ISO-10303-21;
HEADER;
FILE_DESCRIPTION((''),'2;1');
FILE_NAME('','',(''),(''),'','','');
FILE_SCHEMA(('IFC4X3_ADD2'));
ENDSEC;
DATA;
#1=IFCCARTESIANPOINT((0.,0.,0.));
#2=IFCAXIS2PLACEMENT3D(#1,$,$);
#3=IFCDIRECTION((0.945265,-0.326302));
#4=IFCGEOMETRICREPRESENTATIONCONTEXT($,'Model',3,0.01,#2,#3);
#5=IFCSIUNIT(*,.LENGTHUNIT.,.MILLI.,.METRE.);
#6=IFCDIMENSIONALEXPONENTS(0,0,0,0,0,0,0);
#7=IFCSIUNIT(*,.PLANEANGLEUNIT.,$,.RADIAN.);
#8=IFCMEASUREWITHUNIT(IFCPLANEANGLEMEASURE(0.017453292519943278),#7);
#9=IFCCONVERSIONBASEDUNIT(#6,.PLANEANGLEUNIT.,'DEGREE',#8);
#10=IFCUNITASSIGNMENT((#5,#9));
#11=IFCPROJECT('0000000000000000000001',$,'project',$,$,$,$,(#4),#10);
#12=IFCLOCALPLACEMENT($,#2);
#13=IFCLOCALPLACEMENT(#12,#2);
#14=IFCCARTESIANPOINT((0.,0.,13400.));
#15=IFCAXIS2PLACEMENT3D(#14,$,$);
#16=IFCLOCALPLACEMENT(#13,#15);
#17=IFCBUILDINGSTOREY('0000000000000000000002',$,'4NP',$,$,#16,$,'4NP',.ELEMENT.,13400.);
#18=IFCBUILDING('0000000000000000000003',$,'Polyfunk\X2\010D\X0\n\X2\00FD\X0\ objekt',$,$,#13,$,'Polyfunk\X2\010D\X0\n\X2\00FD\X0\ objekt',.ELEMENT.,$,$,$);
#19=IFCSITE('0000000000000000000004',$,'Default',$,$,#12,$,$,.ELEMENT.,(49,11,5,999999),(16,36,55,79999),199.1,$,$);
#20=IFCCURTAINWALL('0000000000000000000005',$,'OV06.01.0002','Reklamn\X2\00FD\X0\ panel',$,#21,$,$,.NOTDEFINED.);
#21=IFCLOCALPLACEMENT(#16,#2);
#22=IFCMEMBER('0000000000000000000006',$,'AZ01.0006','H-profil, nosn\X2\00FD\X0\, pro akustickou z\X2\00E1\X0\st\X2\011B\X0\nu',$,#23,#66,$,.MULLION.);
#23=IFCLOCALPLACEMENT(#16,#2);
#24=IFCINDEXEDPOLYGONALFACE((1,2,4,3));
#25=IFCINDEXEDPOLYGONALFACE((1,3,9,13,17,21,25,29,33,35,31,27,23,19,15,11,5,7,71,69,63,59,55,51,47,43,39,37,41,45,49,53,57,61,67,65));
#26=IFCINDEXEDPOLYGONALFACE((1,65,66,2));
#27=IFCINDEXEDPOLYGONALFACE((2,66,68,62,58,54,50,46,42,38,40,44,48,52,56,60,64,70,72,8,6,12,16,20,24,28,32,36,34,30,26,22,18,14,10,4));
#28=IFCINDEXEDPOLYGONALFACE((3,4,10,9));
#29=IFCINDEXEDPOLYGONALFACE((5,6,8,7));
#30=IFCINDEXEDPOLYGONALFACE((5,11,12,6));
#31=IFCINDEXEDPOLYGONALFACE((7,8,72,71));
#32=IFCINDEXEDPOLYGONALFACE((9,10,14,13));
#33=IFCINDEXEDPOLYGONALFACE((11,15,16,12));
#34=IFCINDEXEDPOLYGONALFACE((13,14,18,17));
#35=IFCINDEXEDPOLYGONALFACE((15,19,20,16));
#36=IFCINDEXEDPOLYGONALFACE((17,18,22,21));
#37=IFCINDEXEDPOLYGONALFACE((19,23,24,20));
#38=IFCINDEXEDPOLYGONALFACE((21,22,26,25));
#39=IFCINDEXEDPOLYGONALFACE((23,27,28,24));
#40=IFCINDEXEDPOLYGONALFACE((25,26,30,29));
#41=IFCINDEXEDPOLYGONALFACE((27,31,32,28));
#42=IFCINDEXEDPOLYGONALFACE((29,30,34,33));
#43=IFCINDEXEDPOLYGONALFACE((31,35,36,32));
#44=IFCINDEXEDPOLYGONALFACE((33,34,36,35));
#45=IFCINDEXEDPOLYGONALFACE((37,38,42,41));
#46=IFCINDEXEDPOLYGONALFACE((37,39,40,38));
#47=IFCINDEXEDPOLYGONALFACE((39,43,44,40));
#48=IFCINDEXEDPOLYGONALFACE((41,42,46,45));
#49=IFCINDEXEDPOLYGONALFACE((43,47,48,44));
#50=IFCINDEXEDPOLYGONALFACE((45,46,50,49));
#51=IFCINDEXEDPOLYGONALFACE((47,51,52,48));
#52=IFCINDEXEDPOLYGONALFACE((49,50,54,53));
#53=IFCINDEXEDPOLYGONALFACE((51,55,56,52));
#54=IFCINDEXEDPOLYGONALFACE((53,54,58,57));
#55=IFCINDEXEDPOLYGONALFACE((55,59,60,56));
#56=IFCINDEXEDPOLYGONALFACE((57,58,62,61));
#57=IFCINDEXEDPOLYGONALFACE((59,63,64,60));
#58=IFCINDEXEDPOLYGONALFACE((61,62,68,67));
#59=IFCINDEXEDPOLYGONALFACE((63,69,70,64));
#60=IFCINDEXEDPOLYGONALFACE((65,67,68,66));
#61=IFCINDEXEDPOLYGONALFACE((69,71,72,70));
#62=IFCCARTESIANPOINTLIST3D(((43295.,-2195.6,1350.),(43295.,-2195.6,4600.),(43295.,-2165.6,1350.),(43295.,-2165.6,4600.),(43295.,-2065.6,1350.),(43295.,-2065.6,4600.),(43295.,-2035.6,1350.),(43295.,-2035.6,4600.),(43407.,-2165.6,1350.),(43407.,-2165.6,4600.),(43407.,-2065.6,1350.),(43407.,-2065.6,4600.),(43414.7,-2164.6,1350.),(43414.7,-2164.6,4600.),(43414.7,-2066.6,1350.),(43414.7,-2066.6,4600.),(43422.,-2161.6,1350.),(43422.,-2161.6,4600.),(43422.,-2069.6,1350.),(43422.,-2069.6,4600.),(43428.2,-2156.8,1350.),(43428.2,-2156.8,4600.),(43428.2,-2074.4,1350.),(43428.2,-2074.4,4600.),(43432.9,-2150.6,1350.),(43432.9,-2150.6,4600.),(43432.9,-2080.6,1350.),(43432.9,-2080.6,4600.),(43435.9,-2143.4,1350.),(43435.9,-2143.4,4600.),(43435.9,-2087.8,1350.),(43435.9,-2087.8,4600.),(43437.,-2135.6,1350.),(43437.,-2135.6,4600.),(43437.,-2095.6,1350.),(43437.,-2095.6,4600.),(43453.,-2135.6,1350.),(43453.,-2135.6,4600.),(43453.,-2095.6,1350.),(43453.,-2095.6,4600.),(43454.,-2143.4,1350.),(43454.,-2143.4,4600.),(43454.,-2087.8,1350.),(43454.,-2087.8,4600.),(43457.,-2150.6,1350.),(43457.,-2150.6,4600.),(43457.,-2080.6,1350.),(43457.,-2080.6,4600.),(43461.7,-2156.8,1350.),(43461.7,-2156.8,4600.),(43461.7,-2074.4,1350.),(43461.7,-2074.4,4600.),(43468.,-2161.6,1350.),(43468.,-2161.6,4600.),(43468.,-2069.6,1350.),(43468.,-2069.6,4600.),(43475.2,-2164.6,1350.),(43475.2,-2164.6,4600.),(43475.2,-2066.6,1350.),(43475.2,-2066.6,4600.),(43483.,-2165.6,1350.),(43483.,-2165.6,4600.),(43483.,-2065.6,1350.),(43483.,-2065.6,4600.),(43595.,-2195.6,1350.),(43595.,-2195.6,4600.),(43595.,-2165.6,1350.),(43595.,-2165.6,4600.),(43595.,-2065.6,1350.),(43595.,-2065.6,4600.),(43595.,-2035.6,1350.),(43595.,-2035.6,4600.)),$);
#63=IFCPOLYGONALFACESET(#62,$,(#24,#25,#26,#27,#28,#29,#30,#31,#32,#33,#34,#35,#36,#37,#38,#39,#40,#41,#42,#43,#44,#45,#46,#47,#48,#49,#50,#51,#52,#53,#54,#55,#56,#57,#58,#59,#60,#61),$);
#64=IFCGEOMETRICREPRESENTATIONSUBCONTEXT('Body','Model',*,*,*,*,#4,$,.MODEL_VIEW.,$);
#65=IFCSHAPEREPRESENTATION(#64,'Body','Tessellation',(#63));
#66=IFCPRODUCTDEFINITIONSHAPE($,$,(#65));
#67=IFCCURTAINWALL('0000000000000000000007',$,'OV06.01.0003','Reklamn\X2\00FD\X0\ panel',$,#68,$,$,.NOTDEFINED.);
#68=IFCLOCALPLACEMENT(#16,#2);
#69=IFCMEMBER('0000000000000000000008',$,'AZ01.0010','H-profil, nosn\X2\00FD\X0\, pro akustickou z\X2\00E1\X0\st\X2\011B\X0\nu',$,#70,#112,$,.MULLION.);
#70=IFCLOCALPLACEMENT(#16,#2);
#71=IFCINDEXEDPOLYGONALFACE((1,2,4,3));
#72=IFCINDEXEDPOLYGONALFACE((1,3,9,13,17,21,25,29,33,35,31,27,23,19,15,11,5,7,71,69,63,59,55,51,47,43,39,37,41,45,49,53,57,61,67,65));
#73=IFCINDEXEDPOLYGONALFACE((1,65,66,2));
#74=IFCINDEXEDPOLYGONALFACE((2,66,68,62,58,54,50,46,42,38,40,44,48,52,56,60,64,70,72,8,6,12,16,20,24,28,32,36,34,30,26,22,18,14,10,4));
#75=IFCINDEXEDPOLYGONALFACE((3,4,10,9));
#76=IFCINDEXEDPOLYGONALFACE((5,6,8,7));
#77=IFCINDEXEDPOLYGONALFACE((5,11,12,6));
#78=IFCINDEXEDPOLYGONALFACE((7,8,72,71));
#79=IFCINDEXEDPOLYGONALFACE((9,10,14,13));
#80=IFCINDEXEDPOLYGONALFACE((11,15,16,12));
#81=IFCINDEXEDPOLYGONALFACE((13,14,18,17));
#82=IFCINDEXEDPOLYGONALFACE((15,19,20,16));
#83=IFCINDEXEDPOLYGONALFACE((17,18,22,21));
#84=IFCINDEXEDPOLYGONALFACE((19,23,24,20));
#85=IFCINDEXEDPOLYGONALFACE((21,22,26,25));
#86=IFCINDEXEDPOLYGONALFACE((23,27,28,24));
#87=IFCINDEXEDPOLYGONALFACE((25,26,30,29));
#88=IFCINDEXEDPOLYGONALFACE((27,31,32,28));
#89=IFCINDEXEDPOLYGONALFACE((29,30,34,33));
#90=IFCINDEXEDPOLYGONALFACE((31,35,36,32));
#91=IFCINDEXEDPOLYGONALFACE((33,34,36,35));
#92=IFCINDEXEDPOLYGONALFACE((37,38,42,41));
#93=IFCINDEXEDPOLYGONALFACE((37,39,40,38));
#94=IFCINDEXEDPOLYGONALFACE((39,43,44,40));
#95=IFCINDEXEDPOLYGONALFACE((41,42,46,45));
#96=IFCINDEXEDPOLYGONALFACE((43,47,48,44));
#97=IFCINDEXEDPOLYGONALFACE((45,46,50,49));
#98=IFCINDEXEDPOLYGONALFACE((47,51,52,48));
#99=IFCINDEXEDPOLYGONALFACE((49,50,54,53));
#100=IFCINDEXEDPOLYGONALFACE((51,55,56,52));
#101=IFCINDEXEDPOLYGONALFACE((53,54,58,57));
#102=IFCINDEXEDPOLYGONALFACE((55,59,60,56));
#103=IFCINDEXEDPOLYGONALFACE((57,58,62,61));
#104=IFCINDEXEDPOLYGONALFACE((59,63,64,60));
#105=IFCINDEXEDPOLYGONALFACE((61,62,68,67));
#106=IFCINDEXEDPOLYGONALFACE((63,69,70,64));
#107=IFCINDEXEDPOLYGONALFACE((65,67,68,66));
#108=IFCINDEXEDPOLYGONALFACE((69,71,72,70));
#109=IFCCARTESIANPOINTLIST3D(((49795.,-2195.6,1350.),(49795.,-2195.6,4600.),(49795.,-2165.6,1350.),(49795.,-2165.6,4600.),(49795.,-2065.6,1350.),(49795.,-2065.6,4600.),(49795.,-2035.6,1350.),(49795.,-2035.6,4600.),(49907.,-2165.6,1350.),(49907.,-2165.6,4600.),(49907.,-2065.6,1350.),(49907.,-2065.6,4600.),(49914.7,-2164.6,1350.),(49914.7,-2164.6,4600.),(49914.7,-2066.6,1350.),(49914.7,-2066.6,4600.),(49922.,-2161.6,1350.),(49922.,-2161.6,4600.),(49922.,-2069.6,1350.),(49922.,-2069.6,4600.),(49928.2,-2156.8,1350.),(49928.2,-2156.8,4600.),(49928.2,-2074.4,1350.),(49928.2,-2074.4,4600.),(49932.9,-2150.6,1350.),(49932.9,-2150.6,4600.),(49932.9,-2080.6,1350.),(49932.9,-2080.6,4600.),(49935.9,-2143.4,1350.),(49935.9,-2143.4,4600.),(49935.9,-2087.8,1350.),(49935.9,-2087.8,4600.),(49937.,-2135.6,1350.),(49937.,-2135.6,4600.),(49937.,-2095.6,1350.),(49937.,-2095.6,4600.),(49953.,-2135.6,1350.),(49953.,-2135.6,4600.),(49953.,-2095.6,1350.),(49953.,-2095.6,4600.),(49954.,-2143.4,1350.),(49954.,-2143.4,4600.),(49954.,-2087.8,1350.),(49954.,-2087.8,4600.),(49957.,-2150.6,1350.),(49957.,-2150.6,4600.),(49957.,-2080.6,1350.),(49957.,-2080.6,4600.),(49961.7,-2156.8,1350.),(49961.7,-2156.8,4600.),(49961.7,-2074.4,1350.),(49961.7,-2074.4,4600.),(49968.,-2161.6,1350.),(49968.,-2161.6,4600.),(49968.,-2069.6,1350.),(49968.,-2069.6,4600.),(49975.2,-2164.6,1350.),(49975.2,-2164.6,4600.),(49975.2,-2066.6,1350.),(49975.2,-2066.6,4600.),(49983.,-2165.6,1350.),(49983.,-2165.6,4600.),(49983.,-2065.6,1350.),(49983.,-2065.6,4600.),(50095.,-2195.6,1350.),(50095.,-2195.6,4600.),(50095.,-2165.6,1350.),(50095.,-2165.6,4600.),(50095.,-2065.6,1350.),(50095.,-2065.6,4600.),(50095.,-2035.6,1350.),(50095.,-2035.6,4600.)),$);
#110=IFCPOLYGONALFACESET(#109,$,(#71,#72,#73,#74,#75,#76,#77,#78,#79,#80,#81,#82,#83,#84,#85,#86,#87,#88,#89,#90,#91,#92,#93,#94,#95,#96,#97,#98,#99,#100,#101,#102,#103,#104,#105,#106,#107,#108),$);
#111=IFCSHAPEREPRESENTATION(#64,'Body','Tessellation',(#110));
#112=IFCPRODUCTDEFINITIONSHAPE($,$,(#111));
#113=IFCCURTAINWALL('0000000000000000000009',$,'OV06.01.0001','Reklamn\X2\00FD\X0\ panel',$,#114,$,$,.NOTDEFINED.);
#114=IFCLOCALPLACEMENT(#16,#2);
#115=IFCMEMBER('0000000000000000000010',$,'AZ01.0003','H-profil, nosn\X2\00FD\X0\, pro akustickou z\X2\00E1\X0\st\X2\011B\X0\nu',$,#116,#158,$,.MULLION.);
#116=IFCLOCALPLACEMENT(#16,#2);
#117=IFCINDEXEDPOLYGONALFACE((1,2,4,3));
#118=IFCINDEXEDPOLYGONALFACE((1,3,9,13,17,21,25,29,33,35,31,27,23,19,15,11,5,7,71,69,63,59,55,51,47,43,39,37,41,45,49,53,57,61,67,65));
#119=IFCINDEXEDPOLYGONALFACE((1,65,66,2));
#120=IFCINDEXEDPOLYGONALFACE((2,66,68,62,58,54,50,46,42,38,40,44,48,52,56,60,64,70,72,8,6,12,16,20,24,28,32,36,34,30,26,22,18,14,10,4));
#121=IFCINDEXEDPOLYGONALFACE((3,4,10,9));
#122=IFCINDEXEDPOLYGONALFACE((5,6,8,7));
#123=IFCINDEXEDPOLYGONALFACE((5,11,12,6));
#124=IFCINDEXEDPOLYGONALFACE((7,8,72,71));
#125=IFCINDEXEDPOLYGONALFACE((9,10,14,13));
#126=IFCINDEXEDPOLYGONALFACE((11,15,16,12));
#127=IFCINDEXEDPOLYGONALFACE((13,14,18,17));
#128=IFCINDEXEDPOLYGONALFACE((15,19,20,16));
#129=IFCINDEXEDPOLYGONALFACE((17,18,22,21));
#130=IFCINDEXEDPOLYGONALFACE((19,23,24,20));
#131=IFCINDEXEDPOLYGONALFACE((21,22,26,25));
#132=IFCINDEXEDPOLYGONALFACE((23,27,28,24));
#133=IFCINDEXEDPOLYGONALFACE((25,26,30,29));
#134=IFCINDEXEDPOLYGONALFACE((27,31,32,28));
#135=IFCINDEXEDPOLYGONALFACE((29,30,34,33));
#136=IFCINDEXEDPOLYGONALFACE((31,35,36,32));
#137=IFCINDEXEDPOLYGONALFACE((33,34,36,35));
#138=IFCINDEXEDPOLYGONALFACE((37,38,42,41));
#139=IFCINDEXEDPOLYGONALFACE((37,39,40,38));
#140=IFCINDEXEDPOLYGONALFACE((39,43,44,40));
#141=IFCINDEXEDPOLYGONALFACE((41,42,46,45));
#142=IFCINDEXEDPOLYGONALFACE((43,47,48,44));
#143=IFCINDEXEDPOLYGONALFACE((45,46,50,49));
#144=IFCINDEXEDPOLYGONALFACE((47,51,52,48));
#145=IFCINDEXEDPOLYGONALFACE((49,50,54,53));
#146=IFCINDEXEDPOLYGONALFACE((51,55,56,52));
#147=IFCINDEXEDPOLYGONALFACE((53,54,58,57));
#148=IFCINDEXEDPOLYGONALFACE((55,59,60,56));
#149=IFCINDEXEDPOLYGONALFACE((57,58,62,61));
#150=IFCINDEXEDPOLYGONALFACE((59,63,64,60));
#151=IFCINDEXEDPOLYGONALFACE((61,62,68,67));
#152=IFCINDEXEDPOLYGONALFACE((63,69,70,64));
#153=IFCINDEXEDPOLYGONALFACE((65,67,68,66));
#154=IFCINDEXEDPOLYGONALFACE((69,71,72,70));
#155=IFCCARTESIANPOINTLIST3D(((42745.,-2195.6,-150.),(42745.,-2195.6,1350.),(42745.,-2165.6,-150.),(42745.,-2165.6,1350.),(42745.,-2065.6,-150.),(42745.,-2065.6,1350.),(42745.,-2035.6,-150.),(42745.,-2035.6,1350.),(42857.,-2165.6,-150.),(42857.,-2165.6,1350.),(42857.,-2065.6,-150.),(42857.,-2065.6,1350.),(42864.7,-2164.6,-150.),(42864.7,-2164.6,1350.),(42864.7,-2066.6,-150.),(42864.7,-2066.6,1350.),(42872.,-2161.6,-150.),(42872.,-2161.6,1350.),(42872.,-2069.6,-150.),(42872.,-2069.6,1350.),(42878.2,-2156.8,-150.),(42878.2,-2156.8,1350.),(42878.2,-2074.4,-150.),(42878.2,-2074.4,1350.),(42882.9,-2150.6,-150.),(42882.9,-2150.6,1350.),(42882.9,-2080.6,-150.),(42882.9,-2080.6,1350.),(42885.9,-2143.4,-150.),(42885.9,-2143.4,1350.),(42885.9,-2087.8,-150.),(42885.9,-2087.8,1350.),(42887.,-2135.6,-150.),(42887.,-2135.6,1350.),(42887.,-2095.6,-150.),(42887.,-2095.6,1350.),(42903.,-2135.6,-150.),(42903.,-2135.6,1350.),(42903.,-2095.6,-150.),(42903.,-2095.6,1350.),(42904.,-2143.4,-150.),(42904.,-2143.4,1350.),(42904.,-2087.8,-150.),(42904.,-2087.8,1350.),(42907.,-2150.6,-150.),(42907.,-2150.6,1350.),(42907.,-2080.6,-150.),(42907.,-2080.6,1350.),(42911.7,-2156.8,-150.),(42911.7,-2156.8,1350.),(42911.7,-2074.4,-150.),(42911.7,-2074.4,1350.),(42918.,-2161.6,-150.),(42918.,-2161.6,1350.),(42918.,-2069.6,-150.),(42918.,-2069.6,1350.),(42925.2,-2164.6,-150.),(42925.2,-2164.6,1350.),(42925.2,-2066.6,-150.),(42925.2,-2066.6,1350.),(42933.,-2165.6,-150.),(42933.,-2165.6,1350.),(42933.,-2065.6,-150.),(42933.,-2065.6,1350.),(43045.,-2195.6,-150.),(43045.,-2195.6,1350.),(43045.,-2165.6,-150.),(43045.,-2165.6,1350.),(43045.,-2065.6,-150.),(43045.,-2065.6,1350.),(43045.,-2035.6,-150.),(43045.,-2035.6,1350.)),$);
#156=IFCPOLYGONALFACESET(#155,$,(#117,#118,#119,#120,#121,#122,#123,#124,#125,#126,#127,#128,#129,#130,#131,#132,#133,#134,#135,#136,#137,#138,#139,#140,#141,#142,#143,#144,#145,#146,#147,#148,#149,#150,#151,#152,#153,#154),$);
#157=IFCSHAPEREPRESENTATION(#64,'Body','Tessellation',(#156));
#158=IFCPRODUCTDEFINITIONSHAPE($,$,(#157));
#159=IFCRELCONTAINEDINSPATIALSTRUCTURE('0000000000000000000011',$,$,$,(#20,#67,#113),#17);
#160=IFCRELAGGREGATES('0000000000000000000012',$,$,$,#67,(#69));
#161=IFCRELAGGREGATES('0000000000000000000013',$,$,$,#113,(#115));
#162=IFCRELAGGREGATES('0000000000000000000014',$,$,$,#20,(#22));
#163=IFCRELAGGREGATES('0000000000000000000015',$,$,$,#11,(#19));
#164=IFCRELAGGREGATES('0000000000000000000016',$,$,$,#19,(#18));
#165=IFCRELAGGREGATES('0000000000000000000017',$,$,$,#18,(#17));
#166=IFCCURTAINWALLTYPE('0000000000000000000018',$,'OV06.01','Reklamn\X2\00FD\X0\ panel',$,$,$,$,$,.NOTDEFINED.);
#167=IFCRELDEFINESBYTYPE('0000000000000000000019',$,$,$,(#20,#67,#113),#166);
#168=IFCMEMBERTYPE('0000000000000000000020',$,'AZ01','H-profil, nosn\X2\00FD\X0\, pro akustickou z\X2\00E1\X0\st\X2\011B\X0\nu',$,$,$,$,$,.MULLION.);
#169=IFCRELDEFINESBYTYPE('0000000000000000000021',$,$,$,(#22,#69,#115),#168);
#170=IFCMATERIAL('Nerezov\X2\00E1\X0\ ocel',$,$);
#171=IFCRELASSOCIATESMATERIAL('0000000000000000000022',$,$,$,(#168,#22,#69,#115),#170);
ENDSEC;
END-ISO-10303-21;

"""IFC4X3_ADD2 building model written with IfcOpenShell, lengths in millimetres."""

from ifc_helpers import new_model, entity, si_unit, converted_unit, direction, frame, frame_2d, origin, place, context, subcontext, project, spatial, polyline, circle_curve, parameter, trimmed, segment, composite_curve, outline, extrude, source, transform, mapped, material, material_profile, profile_set, profile_usage, type_object, element, aggregate, save


model = new_model("IFC4X3_ADD2")

# Units and contexts
model_context = context("Model", 3, precision=0.01, world=origin(), true_north=direction((0.945265, -0.326302)))
body_context = subcontext(model_context, "Body", "Model", "MODEL_VIEW")
ifc_project = project(units=[si_unit("LENGTHUNIT", "METRE", prefix="MILLI"), converted_unit("PLANEANGLEUNIT", "DEGREE", entity("IfcPlaneAngleMeasure", 0.017453292519943278), si_unit("PLANEANGLEUNIT", "RADIAN"), dimensions=[0, 0, 0, 0, 0, 0, 0])], contexts=[model_context])

# Site, building, storey
site_placement = place(None, origin())
site = spatial("IfcSite", under=ifc_project, at=site_placement, Name="Default", CompositionType="ELEMENT", RefLatitude=(49, 11, 5, 999999), RefLongitude=(16, 36, 55, 79999), RefElevation=199.1)
building_placement = place(site_placement, origin())
building = spatial("IfcBuilding", under=site, at=building_placement, Name="Polyfunkčný objekt", LongName="Polyfunkčný objekt", CompositionType="ELEMENT")
storey_placement = place(building_placement, frame((0.0, 0.0, 13400.0)))
storey = spatial("IfcBuildingStorey", under=building, at=storey_placement, Name="4NP", LongName="4NP", CompositionType="ELEMENT", Elevation=13400.0)

# Curtain walls, members
curtain_wall_type = type_object("IfcCurtainWallType", Name="OV06.01", Description="Reklamný panel", PredefinedType="NOTDEFINED")
curtain_wall_1_placement = place(storey_placement, frame((0.0, 0.0, -13400.0)))
curtain_wall_1 = element("IfcCurtainWall", 1, at=curtain_wall_1_placement, inside=storey, type_object=curtain_wall_type, Name="OV06.01.0002", Description="Reklamný panel", PredefinedType="NOTDEFINED")
ifc_material_1 = material(Name="Nerezová ocel")
ifc_material_profile = material_profile(ifc_material_1, outline(composite_curve([segment(polyline([(50.0, -150.0), (80.0, -150.0)]), True, "CONTINUOUS"), segment(polyline([(80.0, -150.0), (80.0, 150.0)]), True, "CONTINUOUS"), segment(polyline([(80.0, 150.0), (50.0, 150.0)]), True, "CONTINUOUS"), segment(polyline([(50.0, 150.0), (50.0, 38.0)]), True, "CONTINUOUS"), segment(trimmed(circle_curve(frame_2d((20.0, 38.0), x_axis=(0.0, 1.0)), 30.0), [parameter(180.0)], [parameter(270.0)], True, "PARAMETER"), False, "CONTINUOUS"), segment(polyline([(20.0, 8.0), (-20.0, 8.0)]), True, "CONTINUOUS"), segment(trimmed(circle_curve(frame_2d((-20.0, 38.0), x_axis=(0.0, 1.0)), 30.0), [parameter(90.0)], [parameter(180.0)], True, "PARAMETER"), False, "CONTINUOUS"), segment(polyline([(-50.0, 38.0), (-50.0, 150.0)]), True, "CONTINUOUS"), segment(polyline([(-50.0, 150.0), (-80.0, 150.0)]), True, "CONTINUOUS"), segment(polyline([(-80.0, 150.0), (-80.0, -150.0)]), True, "CONTINUOUS"), segment(polyline([(-80.0, -150.0), (-50.0, -150.0)]), True, "CONTINUOUS"), segment(polyline([(-50.0, -150.0), (-50.0, -38.0)]), True, "CONTINUOUS"), segment(trimmed(circle_curve(frame_2d((-20.0, -38.0), x_axis=(0.0, 1.0)), 30.0), [parameter(0.0)], [parameter(90.0)], True, "PARAMETER"), False, "CONTINUOUS"), segment(polyline([(-20.0, -8.0), (20.0, -8.0)]), True, "CONTINUOUS"), segment(trimmed(circle_curve(frame_2d((20.0, -38.0), x_axis=(0.0, 1.0)), 30.0), [parameter(270.0)], [parameter(0.0)], True, "PARAMETER"), False, "CONTINUOUS"), segment(polyline([(50.0, -38.0), (50.0, -150.0)]), True, "CONTINUOUS")], self_intersect=False)), Name="Profil zástena")
ifc_profile_set = profile_set([ifc_material_profile], Name="Profil zástena")
ifc_profile_usage = profile_usage(ifc_profile_set)
member_type_1 = type_object("IfcMemberType", Name="AZ01", Description="H-profil, nosný, pro akustickou zástěnu", PredefinedType="MULLION", material=ifc_profile_set)
shared_shape_1 = source(origin(), body_context, "Body", "SweptSolid", [
    extrude(outline(composite_curve([segment(polyline([(50.0, -150.0), (80.0, -150.0)]), True, "CONTINUOUS"), segment(polyline([(80.0, -150.0), (80.0, 150.0)]), True, "CONTINUOUS"), segment(polyline([(80.0, 150.0), (50.0, 150.0)]), True, "CONTINUOUS"), segment(polyline([(50.0, 150.0), (50.0, 38.0)]), True, "CONTINUOUS"), segment(trimmed(circle_curve(frame_2d((20.0, 38.0), x_axis=(0.0, 1.0)), 30.0), [parameter(180.0)], [parameter(270.0)], True, "PARAMETER"), False, "CONTINUOUS"), segment(polyline([(20.0, 8.0), (-20.0, 8.0)]), True, "CONTINUOUS"), segment(trimmed(circle_curve(frame_2d((-20.0, 38.0), x_axis=(0.0, 1.0)), 30.0), [parameter(90.0)], [parameter(180.0)], True, "PARAMETER"), False, "CONTINUOUS"), segment(polyline([(-50.0, 38.0), (-50.0, 150.0)]), True, "CONTINUOUS"), segment(polyline([(-50.0, 150.0), (-80.0, 150.0)]), True, "CONTINUOUS"), segment(polyline([(-80.0, 150.0), (-80.0, -150.0)]), True, "CONTINUOUS"), segment(polyline([(-80.0, -150.0), (-50.0, -150.0)]), True, "CONTINUOUS"), segment(polyline([(-50.0, -150.0), (-50.0, -38.0)]), True, "CONTINUOUS"), segment(trimmed(circle_curve(frame_2d((-20.0, -38.0), x_axis=(0.0, 1.0)), 30.0), [parameter(0.0)], [parameter(90.0)], True, "PARAMETER"), False, "CONTINUOUS"), segment(polyline([(-20.0, -8.0), (20.0, -8.0)]), True, "CONTINUOUS"), segment(trimmed(circle_curve(frame_2d((20.0, -38.0), x_axis=(0.0, 1.0)), 30.0), [parameter(270.0)], [parameter(0.0)], True, "PARAMETER"), False, "CONTINUOUS"), segment(polyline([(50.0, -38.0), (50.0, -150.0)]), True, "CONTINUOUS")], self_intersect=False)), frame((-150.0, 0.0, -3250.0), z_axis=(0.0, 0.0, 1.0), x_axis=(0.0, 1.0, 0.0)), (0.0, 0.0, 1.0), 3250.0),
])
member_1_placement = place(curtain_wall_1_placement, frame((43295.0, -2115.6, 18000.0), z_axis=(0.0, 0.0, 1.0), x_axis=(-1.0, 0.0, 0.0)))
member_1 = element("IfcMember", 2, at=member_1_placement, type_object=member_type_1, material=ifc_profile_usage, Name="AZ01.0006", Description="H-profil, nosný, pro akustickou zástěnu", PredefinedType="MULLION", context=body_context, shape_type="MappedRepresentation", body=[
    mapped(shared_shape_1, transform((0.0, 0.0, 0.0), scale=1.0)),
])
curtain_wall_2_placement = place(storey_placement, frame((0.0, 0.0, -13400.0)))
curtain_wall_2 = element("IfcCurtainWall", 3, at=curtain_wall_2_placement, inside=storey, type_object=curtain_wall_type, Name="OV06.01.0003", Description="Reklamný panel", PredefinedType="NOTDEFINED")
member_2_placement = place(curtain_wall_2_placement, frame((49795.0, -2115.6, 18000.0), z_axis=(0.0, 0.0, 1.0), x_axis=(-1.0, 0.0, 0.0)))
member_2 = element("IfcMember", 4, at=member_2_placement, type_object=member_type_1, material=ifc_profile_usage, Name="AZ01.0010", Description="H-profil, nosný, pro akustickou zástěnu", PredefinedType="MULLION", context=body_context, shape_type="MappedRepresentation", body=[
    mapped(shared_shape_1, transform((0.0, 0.0, 0.0), scale=1.0)),
])
aggregate(curtain_wall_2, [member_2])
curtain_wall_3_placement = place(storey_placement, frame((0.0, 0.0, -13400.0)))
curtain_wall_3 = element("IfcCurtainWall", 5, at=curtain_wall_3_placement, inside=storey, type_object=curtain_wall_type, Name="OV06.01.0001", Description="Reklamný panel", PredefinedType="NOTDEFINED")
shared_shape_2 = source(origin(), body_context, "Body", "SweptSolid", [
    extrude(outline(composite_curve([segment(polyline([(-150.0, -50.0), (-150.0, -80.0)]), True, "CONTINUOUS"), segment(polyline([(-150.0, -80.0), (150.0, -80.0)]), True, "CONTINUOUS"), segment(polyline([(150.0, -80.0), (150.0, -50.0)]), True, "CONTINUOUS"), segment(polyline([(150.0, -50.0), (38.0, -50.0)]), True, "CONTINUOUS"), segment(trimmed(circle_curve(frame_2d((38.0, -20.0), x_axis=(1.0, 0.0)), 30.0), [parameter(180.0)], [parameter(270.0)], True, "PARAMETER"), False, "CONTINUOUS"), segment(polyline([(8.0, -20.0), (8.0, 20.0)]), True, "CONTINUOUS"), segment(trimmed(circle_curve(frame_2d((38.0, 20.0), x_axis=(1.0, 0.0)), 30.0), [parameter(90.0)], [parameter(180.0)], True, "PARAMETER"), False, "CONTINUOUS"), segment(polyline([(38.0, 50.0), (150.0, 50.0)]), True, "CONTINUOUS"), segment(polyline([(150.0, 50.0), (150.0, 80.0)]), True, "CONTINUOUS"), segment(polyline([(150.0, 80.0), (-150.0, 80.0)]), True, "CONTINUOUS"), segment(polyline([(-150.0, 80.0), (-150.0, 50.0)]), True, "CONTINUOUS"), segment(polyline([(-150.0, 50.0), (-38.0, 50.0)]), True, "CONTINUOUS"), segment(trimmed(circle_curve(frame_2d((-38.0, 20.0), x_axis=(1.0, 0.0)), 30.0), [parameter(0.0)], [parameter(90.0)], True, "PARAMETER"), False, "CONTINUOUS"), segment(polyline([(-8.0, 20.0), (-8.0, -20.0)]), True, "CONTINUOUS"), segment(trimmed(circle_curve(frame_2d((-38.0, -20.0), x_axis=(1.0, 0.0)), 30.0), [parameter(270.0)], [parameter(0.0)], True, "PARAMETER"), False, "CONTINUOUS"), segment(polyline([(-38.0, -50.0), (-150.0, -50.0)]), True, "CONTINUOUS")], self_intersect=False)), frame((-150.0, 0.0, -1500.0), z_axis=(0.0, 0.0, -1.0), x_axis=(1.0, 0.0, 0.0)), (0.0, 0.0, -1.0), 1500.0),
])
member_3_placement = place(curtain_wall_3_placement, frame((43045.0, -2115.6, 13250.0), z_axis=(0.0, 0.0, -1.0), x_axis=(1.0, 0.0, 0.0)))
member_3 = element("IfcMember", 6, at=member_3_placement, type_object=member_type_1, material=ifc_profile_usage, Name="AZ01.0003", Description="H-profil, nosný, pro akustickou zástěnu", PredefinedType="MULLION", context=body_context, shape_type="MappedRepresentation", body=[
    mapped(shared_shape_2, transform((0.0, 0.0, 0.0), scale=1.0)),
])

aggregate(curtain_wall_3, [member_3])
aggregate(curtain_wall_1, [member_1])

save(model, "model.ifc")
